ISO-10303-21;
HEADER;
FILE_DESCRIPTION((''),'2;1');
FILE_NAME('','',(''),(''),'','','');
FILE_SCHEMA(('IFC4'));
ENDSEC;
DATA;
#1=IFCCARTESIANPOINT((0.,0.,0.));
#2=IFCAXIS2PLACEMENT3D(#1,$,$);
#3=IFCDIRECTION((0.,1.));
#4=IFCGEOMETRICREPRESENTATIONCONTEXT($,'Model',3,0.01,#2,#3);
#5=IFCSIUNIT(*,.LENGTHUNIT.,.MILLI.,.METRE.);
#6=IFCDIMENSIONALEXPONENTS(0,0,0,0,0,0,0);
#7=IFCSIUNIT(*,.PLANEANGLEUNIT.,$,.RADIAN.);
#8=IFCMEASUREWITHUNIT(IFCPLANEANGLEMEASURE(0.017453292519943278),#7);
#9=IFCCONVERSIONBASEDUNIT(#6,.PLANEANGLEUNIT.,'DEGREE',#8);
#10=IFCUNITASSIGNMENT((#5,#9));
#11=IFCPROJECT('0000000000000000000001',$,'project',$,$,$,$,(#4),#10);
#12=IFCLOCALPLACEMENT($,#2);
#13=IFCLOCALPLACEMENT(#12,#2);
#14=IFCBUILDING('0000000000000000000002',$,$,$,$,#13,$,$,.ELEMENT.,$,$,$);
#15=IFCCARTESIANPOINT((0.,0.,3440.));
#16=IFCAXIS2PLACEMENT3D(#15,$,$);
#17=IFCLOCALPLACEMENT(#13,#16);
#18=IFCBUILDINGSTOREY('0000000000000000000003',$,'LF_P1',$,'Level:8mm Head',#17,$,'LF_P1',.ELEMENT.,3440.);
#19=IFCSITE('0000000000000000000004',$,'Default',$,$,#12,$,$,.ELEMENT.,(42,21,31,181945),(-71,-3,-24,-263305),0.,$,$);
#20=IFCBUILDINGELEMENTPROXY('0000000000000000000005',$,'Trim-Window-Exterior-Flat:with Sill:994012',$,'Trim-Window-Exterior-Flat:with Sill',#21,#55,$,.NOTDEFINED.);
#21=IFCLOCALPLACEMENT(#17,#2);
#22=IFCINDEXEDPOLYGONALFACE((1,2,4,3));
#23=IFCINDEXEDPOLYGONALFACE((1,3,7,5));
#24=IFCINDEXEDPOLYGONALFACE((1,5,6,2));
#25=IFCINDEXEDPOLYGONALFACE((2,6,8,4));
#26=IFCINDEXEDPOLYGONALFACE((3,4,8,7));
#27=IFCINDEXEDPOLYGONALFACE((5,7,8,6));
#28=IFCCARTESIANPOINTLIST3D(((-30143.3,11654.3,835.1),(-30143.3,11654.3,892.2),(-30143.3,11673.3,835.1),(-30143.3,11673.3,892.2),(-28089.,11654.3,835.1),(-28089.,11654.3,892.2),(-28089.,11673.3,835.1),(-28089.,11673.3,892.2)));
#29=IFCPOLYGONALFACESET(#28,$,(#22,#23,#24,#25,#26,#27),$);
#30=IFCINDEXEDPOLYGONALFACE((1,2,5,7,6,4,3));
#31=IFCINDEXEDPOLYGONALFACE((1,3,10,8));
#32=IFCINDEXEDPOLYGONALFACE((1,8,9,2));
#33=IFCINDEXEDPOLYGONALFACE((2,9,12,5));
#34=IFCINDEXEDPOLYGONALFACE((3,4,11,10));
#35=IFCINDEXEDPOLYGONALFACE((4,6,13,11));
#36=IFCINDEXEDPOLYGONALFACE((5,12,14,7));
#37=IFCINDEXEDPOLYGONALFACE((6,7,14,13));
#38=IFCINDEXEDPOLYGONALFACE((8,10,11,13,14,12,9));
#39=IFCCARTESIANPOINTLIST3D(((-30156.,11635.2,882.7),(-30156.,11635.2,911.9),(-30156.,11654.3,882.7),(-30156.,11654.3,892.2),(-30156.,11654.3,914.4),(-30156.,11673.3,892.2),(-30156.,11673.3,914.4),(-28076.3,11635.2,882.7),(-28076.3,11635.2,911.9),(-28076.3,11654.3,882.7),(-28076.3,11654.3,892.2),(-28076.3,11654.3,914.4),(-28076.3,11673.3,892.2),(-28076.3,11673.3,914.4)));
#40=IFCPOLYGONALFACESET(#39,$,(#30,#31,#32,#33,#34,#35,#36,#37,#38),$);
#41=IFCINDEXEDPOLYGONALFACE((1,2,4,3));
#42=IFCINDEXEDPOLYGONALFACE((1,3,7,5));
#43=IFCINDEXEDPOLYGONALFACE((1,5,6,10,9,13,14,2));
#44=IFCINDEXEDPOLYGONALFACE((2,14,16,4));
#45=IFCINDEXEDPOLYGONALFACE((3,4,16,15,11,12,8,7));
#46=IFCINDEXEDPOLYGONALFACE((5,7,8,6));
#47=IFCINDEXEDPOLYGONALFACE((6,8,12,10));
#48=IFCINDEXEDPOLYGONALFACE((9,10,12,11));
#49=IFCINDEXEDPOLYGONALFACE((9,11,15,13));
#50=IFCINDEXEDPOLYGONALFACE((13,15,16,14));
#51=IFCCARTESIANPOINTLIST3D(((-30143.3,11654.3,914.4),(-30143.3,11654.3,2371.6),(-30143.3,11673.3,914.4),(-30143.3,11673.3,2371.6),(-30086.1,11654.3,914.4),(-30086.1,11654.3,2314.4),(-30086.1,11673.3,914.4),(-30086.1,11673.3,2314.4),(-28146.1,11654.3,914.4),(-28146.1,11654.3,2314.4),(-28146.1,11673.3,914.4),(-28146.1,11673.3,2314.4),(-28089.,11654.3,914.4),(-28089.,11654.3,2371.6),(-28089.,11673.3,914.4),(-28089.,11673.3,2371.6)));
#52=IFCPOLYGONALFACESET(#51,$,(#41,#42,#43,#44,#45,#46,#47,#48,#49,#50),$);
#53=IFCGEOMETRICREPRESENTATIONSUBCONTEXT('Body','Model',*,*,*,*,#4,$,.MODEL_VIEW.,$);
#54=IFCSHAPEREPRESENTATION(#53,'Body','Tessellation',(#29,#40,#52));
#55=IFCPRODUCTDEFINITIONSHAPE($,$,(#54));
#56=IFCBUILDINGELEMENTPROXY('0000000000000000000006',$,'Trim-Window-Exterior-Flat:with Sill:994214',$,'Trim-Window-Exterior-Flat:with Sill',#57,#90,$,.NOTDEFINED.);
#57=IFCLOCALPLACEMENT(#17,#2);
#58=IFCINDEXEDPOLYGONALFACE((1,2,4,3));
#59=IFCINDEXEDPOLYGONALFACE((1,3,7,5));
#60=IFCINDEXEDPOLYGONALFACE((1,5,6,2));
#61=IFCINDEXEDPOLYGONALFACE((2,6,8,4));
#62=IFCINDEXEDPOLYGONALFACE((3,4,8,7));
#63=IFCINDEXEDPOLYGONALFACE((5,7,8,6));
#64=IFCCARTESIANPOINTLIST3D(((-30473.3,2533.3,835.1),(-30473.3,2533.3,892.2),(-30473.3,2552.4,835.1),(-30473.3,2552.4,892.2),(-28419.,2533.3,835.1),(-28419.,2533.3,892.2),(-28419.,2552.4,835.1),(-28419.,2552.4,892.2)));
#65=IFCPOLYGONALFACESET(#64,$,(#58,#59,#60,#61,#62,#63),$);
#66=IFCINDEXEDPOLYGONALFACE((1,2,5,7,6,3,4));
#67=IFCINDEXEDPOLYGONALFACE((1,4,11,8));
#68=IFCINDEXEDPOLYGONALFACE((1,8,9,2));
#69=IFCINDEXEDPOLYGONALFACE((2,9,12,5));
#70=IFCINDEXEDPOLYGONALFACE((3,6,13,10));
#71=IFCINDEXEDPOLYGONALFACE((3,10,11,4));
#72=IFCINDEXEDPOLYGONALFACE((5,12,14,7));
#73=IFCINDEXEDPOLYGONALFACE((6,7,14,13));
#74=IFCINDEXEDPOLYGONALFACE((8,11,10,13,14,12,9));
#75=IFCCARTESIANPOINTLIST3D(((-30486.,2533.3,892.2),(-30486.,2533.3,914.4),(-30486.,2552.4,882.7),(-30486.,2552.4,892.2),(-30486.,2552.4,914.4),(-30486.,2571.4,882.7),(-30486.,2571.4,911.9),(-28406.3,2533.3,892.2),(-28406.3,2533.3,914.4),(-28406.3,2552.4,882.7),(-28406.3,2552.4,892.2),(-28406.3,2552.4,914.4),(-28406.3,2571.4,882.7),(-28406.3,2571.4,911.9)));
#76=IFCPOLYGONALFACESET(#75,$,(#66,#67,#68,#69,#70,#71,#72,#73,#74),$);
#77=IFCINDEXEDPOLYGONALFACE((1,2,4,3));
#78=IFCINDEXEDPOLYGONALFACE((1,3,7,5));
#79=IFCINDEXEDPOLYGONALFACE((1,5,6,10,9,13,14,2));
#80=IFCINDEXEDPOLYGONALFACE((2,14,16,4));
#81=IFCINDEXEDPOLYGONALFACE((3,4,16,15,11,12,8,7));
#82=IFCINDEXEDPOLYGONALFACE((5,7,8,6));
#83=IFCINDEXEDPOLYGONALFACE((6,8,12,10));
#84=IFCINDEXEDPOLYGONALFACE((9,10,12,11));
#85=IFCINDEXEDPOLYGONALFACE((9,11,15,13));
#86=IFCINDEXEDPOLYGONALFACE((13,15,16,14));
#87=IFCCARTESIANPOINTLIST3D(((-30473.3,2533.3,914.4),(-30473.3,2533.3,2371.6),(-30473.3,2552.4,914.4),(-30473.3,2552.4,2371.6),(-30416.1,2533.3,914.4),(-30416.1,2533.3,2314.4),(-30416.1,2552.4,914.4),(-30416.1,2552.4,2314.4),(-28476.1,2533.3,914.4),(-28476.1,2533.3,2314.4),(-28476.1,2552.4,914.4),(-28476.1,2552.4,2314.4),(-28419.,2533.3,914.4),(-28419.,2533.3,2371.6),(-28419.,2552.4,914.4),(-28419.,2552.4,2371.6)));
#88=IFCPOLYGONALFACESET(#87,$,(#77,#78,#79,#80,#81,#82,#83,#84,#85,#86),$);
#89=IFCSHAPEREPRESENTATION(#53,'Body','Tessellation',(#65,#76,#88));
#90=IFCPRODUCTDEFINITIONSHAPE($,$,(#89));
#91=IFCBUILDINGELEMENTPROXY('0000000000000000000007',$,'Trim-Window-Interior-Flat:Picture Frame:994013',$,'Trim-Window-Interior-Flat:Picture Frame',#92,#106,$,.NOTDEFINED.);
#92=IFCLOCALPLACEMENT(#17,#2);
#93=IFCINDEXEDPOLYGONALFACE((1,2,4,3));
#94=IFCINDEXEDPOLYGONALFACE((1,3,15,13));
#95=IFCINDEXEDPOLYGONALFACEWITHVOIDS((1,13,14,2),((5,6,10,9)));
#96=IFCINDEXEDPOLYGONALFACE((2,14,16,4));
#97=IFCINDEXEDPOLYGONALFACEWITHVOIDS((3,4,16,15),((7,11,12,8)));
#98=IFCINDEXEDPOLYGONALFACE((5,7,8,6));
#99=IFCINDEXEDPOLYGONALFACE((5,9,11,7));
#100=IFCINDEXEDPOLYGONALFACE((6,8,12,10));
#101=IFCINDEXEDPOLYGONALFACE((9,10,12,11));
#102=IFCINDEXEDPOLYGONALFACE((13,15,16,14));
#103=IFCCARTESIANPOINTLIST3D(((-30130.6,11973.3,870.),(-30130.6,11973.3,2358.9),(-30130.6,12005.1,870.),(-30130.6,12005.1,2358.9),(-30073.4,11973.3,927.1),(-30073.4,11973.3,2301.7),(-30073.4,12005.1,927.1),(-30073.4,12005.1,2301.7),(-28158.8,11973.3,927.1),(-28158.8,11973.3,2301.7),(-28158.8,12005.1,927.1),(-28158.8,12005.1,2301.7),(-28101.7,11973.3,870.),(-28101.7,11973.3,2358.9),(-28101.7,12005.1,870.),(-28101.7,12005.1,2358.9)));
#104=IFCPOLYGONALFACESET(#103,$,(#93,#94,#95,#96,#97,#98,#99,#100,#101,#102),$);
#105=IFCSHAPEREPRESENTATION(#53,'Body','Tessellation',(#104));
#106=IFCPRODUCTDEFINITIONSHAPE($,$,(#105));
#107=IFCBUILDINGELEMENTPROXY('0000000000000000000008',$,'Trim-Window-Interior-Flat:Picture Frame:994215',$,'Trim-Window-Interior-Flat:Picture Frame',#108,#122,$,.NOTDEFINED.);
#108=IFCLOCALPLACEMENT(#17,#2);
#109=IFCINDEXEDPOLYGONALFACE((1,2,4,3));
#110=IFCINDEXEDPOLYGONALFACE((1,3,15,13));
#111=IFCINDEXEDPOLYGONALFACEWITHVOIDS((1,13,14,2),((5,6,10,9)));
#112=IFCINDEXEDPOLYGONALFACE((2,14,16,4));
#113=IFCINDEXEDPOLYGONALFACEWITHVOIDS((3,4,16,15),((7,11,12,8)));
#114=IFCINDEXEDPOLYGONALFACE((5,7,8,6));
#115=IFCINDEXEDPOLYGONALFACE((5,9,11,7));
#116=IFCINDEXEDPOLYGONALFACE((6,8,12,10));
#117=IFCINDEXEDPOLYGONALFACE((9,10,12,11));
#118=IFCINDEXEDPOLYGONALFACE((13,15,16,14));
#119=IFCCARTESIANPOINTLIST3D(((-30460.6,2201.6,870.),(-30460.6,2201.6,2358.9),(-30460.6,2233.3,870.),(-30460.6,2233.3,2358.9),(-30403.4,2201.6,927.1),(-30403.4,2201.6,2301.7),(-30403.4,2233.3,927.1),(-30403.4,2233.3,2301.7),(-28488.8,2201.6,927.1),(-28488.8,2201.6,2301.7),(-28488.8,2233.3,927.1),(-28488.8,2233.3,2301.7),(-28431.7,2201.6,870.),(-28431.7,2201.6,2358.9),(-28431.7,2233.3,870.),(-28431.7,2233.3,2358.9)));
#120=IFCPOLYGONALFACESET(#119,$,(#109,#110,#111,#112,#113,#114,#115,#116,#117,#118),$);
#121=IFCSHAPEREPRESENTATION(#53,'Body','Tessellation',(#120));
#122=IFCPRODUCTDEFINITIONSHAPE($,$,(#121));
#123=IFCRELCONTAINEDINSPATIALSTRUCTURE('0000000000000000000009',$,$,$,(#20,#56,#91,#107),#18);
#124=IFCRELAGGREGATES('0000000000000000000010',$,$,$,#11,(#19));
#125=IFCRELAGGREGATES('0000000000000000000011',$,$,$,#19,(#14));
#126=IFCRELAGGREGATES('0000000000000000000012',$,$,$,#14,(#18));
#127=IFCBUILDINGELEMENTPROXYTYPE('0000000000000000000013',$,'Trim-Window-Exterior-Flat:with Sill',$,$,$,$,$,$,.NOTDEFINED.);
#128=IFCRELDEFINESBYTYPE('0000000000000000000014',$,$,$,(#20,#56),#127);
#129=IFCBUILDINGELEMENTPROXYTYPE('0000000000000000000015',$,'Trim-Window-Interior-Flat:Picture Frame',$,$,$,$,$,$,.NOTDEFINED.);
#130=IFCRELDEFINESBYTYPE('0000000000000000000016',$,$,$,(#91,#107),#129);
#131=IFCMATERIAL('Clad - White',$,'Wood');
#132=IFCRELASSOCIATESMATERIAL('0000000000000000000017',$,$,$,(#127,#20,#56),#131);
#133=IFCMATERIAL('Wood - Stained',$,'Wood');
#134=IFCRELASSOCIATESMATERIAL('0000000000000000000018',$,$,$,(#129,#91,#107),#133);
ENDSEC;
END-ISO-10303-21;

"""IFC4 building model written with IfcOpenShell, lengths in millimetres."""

from ifc_helpers import new_model, entity, si_unit, converted_unit, direction, frame, origin, place, context, subcontext, project, spatial, indexed_curve, outline, extrude, source, transform, mapped, material, type_object, type_shapes, element, save


model = new_model("IFC4")

# Units and contexts
model_context = context("Model", 3, precision=0.01, world=origin(), true_north=direction((0.0, 1.0)))
body_context = subcontext(model_context, "Body", "Model", "MODEL_VIEW")
ifc_project = project(units=[si_unit("LENGTHUNIT", "METRE", prefix="MILLI"), converted_unit("PLANEANGLEUNIT", "DEGREE", entity("IfcPlaneAngleMeasure", 0.017453292519943278), si_unit("PLANEANGLEUNIT", "RADIAN"), dimensions=[0, 0, 0, 0, 0, 0, 0])], contexts=[model_context])

# Site, building, storey
site_placement = place(None, origin())
site = spatial("IfcSite", under=ifc_project, at=site_placement, Name="Default", CompositionType="ELEMENT", RefLatitude=(42, 21, 31, 181945), RefLongitude=(-71, -3, -24, -263305), RefElevation=0.0)
building_placement = place(site_placement, origin())
building = spatial("IfcBuilding", under=site, at=building_placement, CompositionType="ELEMENT")
storey_placement = place(building_placement, frame((0.0, 0.0, 3440.0)))
storey = spatial("IfcBuildingStorey", under=building, at=storey_placement, Name="LF_P1", ObjectType="Level:8mm Head", LongName="LF_P1", CompositionType="ELEMENT", Elevation=3440.0)

# Building element proxies
ifc_material_1 = material(Name="Clad - White", Category="Wood")
ifc_material_2 = material(Name="Wood - Stained", Category="Wood")
building_element_proxy_type_1 = type_object("IfcBuildingElementProxyType", Name="Trim-Window-Exterior-Flat:with Sill", PredefinedType="NOTDEFINED", material=ifc_material_1)
shared_shape_1 = source(origin(), body_context, "Body", "SweptSolid", [
    extrude(outline(indexed_curve([(-28.6, -1027.1), (28.6, -1027.1), (28.6, 1027.1), (-28.6, 1027.1), (-28.6, -1027.1)], self_intersect=False)), frame((0.0, 1450.8, 0.0), z_axis=(0.0, 0.0, 1.0), x_axis=(0.0, 1.0, 0.0)), (0.0, 0.0, 1.0), 19.0),
    extrude(outline(indexed_curve([(-16.0, -19.0), (13.3, -19.0), (15.8, 0.0), (15.8, 19.0), (-6.4, 19.0), (-6.4, 0.0), (-16.0, 0.0), (-16.0, -19.0)], self_intersect=False)), frame((-1039.8, 1415.8, 19.0), z_axis=(1.0, 0.0, 0.0), x_axis=(0.0, -1.0, 0.0)), (0.0, 0.0, 1.0), 2079.7),
    extrude(outline(indexed_curve([(-1027.1, -742.9), (1027.1, -742.9), (1027.1, 714.3), (970.0, 714.3), (970.0, -685.7), (-970.0, -685.7), (-970.0, 714.3), (-1027.1, 714.3), (-1027.1, -742.9)], self_intersect=False)), frame((0.0, 685.7, 0.0)), (0.0, 0.0, 1.0), 19.0),
])
type_shapes(building_element_proxy_type_1, [shared_shape_1])
for number, where, z_axis, x_axis, name in (
    (1, (-29116.1, 11673.3, 2314.4), (0.0, -1.0, 0.0), (-1.0, 0.0, 0.0), "Trim-Window-Exterior-Flat:with Sill:994012"),
    (2, (-29446.1, 2533.3, 2314.4), (0.0, 1.0, 0.0), (1.0, 0.0, 0.0), "Trim-Window-Exterior-Flat:with Sill:994214"),
):
    element("IfcBuildingElementProxy", number, at=place(storey_placement, frame(where, z_axis=z_axis, x_axis=x_axis)), inside=storey, type_object=building_element_proxy_type_1, material=ifc_material_1, Name=name, ObjectType="Trim-Window-Exterior-Flat:with Sill", PredefinedType="NOTDEFINED", context=body_context, shape_type="MappedRepresentation", body=[
        mapped(shared_shape_1, transform((0.0, 0.0, 0.0), scale=1.0)),
    ])
building_element_proxy_type_2 = type_object("IfcBuildingElementProxyType", Name="Trim-Window-Interior-Flat:Picture Frame", PredefinedType="NOTDEFINED", material=ifc_material_2)
shared_shape_2 = source(origin(), body_context, "Body", "SweptSolid", [
    extrude(outline(indexed_curve([(-744.4, -1014.4), (744.4, -1014.4), (744.4, 1014.4), (-744.4, 1014.4), (-744.4, -1014.4)], self_intersect=False), holes=[indexed_curve([(-687.3, -957.3), (-687.3, 957.3), (687.3, 957.3), (687.3, -957.3), (-687.3, -957.3)], self_intersect=False)]), frame((0.0, 700.0, 0.0), z_axis=(0.0, 0.0, 1.0), x_axis=(0.0, 1.0, 0.0)), (0.0, 0.0, 1.0), 31.7),
])
type_shapes(building_element_proxy_type_2, [shared_shape_2])
for number, where, z_axis, x_axis, name in (
    (3, (-29116.1, 11973.3, 2314.4), (0.0, 1.0, 0.0), (1.0, 0.0, 0.0), "Trim-Window-Interior-Flat:Picture Frame:994013"),
    (4, (-29446.1, 2233.3, 2314.4), (0.0, -1.0, 0.0), (-1.0, 0.0, 0.0), "Trim-Window-Interior-Flat:Picture Frame:994215"),
):
    element("IfcBuildingElementProxy", number, at=place(storey_placement, frame(where, z_axis=z_axis, x_axis=x_axis)), inside=storey, type_object=building_element_proxy_type_2, material=ifc_material_2, Name=name, ObjectType="Trim-Window-Interior-Flat:Picture Frame", PredefinedType="NOTDEFINED", context=body_context, shape_type="MappedRepresentation", body=[
        mapped(shared_shape_2, transform((0.0, 0.0, 0.0), scale=1.0)),
    ])

save(model, "model.ifc")
